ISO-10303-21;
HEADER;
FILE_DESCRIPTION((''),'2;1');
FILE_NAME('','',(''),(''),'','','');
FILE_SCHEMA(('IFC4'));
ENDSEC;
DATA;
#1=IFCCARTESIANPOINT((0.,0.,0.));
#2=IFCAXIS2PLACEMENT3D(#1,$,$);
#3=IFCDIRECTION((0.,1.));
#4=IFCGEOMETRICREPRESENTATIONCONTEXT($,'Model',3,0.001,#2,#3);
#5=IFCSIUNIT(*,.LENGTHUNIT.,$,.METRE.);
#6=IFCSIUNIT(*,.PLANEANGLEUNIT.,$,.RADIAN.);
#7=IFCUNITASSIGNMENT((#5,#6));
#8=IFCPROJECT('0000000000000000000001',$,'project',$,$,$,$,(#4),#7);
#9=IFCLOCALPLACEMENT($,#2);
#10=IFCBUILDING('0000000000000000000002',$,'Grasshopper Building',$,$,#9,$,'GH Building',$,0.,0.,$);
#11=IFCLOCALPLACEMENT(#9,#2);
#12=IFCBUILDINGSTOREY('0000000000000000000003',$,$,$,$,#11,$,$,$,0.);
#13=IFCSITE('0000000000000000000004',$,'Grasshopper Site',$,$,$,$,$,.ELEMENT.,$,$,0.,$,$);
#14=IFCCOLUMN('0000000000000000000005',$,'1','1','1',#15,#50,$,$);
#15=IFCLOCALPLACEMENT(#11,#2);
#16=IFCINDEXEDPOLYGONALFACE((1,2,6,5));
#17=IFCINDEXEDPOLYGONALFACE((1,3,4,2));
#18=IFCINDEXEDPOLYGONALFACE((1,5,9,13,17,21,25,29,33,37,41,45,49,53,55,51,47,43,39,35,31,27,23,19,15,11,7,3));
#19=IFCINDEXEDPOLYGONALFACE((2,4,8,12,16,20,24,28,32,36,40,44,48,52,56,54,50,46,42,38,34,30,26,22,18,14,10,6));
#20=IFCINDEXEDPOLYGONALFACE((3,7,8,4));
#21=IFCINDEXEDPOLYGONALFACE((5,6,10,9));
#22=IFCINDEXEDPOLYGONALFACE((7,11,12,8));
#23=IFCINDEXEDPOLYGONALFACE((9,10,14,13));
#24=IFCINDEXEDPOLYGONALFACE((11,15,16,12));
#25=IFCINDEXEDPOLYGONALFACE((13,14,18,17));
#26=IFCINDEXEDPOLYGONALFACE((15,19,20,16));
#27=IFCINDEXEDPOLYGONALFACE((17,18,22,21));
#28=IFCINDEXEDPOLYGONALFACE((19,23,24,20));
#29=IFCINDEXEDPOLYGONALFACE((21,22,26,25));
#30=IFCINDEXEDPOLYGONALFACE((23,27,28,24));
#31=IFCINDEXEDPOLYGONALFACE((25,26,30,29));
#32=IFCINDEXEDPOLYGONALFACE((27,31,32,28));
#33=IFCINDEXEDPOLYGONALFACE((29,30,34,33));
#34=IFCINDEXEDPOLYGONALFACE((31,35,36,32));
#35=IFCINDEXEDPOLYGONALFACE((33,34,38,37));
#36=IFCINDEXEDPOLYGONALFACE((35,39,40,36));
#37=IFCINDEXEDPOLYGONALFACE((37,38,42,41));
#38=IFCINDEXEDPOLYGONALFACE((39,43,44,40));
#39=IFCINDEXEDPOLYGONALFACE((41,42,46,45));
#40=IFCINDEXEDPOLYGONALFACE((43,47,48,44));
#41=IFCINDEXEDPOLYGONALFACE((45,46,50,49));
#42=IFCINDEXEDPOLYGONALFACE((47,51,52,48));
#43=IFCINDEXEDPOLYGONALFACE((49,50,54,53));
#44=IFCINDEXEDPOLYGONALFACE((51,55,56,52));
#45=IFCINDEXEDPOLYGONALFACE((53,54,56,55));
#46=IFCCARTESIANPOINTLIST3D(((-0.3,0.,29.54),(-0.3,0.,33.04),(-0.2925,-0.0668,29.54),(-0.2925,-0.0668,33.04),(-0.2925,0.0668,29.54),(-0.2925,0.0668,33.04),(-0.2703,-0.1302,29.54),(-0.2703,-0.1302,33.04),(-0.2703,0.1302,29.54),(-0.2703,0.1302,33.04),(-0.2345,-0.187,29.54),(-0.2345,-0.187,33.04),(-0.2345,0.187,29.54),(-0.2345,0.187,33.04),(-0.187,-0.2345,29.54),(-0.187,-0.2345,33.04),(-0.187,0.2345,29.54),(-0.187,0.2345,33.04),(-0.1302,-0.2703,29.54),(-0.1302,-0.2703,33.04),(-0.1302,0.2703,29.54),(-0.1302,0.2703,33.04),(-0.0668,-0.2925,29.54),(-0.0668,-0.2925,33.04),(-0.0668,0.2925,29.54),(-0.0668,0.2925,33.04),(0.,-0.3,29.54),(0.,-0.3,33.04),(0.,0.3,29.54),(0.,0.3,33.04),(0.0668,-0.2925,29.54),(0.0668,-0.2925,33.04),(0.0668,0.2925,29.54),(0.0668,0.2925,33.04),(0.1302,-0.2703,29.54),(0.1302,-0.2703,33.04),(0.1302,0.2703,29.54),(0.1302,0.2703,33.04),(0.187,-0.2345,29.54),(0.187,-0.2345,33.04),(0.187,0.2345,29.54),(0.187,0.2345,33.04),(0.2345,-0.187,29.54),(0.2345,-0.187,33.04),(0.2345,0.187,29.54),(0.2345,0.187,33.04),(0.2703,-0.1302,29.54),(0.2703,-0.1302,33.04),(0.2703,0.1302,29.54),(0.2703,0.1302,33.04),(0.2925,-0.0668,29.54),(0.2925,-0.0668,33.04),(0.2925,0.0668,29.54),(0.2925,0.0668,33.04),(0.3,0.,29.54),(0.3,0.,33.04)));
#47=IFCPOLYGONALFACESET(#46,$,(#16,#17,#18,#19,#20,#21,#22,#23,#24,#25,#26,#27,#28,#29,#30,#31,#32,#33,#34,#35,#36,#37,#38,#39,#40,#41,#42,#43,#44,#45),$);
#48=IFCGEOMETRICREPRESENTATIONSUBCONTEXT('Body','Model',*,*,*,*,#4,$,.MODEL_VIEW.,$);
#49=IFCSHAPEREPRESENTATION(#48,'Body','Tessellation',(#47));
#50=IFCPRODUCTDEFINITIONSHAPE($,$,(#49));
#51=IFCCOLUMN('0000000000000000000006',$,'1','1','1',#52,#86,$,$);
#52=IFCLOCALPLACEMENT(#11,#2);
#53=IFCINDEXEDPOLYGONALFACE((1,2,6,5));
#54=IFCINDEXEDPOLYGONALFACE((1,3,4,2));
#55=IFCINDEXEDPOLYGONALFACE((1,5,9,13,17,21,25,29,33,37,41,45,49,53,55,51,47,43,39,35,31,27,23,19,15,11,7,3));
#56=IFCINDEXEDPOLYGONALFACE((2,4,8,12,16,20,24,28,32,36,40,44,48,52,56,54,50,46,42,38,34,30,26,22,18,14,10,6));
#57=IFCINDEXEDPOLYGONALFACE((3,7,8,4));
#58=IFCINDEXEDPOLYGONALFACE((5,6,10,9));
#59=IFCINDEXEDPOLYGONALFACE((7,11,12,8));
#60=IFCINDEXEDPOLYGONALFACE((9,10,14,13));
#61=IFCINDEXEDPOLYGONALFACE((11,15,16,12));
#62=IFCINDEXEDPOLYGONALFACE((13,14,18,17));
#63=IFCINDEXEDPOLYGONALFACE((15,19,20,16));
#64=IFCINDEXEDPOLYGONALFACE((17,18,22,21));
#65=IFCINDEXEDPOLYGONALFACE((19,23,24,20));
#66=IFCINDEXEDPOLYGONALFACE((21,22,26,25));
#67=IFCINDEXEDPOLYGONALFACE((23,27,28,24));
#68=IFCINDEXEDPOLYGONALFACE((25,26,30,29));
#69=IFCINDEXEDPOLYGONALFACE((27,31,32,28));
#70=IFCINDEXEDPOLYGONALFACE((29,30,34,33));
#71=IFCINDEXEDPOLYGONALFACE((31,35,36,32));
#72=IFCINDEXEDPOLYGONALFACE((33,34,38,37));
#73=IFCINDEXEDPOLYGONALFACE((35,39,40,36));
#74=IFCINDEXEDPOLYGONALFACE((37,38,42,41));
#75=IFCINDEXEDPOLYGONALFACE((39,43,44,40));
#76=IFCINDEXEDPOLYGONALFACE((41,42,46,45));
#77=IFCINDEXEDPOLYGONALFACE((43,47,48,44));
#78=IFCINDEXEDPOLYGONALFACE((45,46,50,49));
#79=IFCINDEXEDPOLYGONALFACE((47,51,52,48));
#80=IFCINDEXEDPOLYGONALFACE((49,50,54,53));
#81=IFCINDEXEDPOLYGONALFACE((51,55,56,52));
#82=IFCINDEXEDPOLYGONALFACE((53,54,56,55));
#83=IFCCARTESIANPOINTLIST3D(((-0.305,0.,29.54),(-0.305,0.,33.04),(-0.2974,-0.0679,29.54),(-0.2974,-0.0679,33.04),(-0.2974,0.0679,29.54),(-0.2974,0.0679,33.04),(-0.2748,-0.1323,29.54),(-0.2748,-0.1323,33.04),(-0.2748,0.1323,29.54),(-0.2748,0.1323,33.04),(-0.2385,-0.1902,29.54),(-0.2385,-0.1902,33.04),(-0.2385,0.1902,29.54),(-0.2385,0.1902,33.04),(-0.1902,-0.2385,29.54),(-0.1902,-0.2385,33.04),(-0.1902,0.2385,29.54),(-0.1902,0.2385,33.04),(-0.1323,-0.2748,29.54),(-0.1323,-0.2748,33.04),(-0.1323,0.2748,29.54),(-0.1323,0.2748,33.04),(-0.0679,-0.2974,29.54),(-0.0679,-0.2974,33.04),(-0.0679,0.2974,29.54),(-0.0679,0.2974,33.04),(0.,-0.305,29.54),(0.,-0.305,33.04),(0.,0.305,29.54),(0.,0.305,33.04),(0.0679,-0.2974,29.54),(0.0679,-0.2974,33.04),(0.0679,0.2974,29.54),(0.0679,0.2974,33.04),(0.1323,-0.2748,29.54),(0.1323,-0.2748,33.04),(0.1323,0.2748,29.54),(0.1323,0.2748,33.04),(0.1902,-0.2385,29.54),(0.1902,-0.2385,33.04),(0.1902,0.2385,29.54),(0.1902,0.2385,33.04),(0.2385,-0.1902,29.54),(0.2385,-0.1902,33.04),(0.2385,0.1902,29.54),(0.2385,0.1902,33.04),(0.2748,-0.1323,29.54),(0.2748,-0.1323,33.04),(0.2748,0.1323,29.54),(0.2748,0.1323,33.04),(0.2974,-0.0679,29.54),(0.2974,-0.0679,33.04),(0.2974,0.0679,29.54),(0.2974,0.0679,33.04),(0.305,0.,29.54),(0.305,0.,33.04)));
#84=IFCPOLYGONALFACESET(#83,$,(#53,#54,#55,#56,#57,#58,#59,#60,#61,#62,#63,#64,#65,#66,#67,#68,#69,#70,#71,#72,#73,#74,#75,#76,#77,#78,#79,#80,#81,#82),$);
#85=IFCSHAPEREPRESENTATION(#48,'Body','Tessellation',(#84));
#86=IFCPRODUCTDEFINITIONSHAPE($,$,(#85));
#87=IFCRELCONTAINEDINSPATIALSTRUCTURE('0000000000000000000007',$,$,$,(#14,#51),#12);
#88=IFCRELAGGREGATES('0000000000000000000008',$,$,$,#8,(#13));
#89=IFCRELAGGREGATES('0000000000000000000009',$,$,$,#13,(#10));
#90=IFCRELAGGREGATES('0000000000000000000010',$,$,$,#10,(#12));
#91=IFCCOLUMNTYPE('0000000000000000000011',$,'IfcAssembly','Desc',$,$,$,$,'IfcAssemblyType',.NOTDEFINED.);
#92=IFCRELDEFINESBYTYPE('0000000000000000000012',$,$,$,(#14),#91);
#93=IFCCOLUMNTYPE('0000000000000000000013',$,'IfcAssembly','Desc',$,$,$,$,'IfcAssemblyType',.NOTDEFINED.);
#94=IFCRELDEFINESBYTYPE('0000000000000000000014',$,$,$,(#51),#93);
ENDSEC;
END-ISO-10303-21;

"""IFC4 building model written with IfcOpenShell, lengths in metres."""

from ifc_helpers import new_model, si_unit, direction, frame, origin, place, context, subcontext, project, spatial, circle, extrude, source, transform, mapped, type_object, type_shapes, element, save


model = new_model("IFC4")

# Units and contexts
model_context = context("Model", 3, precision=0.001, world=origin(), true_north=direction((0.0, 1.0)))
body_context = subcontext(model_context, "Body", "Model", "MODEL_VIEW")
ifc_project = project(units=[si_unit("LENGTHUNIT", "METRE"), si_unit("PLANEANGLEUNIT", "RADIAN")], contexts=[model_context])

# Site, building, storey
site = spatial("IfcSite", under=ifc_project, Name="Grasshopper Site", CompositionType="ELEMENT", RefElevation=0.0)
building_placement = place(None, origin())
building = spatial("IfcBuilding", under=site, at=building_placement, Name="Grasshopper Building", LongName="GH Building", ElevationOfRefHeight=0.0, ElevationOfTerrain=0.0)
storey_placement = place(building_placement, origin())
storey = spatial("IfcBuildingStorey", under=building, at=storey_placement, Elevation=0.0)

# Columns
column_type_1 = type_object("IfcColumnType", Name="IfcAssembly", Description="Desc", ElementType="IfcAssemblyType", PredefinedType="NOTDEFINED")
shared_shape_1 = source(origin(), body_context, "Body", "SweptSolid", [
    extrude(circle(Radius=0.3), frame((0.0, 0.0, 29.54)), (0.0, 0.0, 1.0), 3.5),
])
type_shapes(column_type_1, [shared_shape_1])
column_1_placement = place(storey_placement, origin())
element("IfcColumn", 1, at=column_1_placement, inside=storey, type_object=column_type_1, Name="1", Description="1", ObjectType="1", context=body_context, shape_type="MappedRepresentation", body=[
    mapped(shared_shape_1, transform((0.0, 0.0, 0.0), scale=1.0)),
])
column_type_2 = type_object("IfcColumnType", Name="IfcAssembly", Description="Desc", ElementType="IfcAssemblyType", PredefinedType="NOTDEFINED")
shared_shape_2 = source(origin(), body_context, "Body", "SweptSolid", [
    extrude(circle(Radius=0.305), frame((0.0, 0.0, 29.54)), (0.0, 0.0, 1.0), 3.5),
])
type_shapes(column_type_2, [shared_shape_2])
column_2_placement = place(storey_placement, origin())
element("IfcColumn", 2, at=column_2_placement, inside=storey, type_object=column_type_2, Name="1", Description="1", ObjectType="1", context=body_context, shape_type="MappedRepresentation", body=[
    mapped(shared_shape_2, transform((0.0, 0.0, 0.0), scale=1.0)),
])

save(model, "model.ifc")
